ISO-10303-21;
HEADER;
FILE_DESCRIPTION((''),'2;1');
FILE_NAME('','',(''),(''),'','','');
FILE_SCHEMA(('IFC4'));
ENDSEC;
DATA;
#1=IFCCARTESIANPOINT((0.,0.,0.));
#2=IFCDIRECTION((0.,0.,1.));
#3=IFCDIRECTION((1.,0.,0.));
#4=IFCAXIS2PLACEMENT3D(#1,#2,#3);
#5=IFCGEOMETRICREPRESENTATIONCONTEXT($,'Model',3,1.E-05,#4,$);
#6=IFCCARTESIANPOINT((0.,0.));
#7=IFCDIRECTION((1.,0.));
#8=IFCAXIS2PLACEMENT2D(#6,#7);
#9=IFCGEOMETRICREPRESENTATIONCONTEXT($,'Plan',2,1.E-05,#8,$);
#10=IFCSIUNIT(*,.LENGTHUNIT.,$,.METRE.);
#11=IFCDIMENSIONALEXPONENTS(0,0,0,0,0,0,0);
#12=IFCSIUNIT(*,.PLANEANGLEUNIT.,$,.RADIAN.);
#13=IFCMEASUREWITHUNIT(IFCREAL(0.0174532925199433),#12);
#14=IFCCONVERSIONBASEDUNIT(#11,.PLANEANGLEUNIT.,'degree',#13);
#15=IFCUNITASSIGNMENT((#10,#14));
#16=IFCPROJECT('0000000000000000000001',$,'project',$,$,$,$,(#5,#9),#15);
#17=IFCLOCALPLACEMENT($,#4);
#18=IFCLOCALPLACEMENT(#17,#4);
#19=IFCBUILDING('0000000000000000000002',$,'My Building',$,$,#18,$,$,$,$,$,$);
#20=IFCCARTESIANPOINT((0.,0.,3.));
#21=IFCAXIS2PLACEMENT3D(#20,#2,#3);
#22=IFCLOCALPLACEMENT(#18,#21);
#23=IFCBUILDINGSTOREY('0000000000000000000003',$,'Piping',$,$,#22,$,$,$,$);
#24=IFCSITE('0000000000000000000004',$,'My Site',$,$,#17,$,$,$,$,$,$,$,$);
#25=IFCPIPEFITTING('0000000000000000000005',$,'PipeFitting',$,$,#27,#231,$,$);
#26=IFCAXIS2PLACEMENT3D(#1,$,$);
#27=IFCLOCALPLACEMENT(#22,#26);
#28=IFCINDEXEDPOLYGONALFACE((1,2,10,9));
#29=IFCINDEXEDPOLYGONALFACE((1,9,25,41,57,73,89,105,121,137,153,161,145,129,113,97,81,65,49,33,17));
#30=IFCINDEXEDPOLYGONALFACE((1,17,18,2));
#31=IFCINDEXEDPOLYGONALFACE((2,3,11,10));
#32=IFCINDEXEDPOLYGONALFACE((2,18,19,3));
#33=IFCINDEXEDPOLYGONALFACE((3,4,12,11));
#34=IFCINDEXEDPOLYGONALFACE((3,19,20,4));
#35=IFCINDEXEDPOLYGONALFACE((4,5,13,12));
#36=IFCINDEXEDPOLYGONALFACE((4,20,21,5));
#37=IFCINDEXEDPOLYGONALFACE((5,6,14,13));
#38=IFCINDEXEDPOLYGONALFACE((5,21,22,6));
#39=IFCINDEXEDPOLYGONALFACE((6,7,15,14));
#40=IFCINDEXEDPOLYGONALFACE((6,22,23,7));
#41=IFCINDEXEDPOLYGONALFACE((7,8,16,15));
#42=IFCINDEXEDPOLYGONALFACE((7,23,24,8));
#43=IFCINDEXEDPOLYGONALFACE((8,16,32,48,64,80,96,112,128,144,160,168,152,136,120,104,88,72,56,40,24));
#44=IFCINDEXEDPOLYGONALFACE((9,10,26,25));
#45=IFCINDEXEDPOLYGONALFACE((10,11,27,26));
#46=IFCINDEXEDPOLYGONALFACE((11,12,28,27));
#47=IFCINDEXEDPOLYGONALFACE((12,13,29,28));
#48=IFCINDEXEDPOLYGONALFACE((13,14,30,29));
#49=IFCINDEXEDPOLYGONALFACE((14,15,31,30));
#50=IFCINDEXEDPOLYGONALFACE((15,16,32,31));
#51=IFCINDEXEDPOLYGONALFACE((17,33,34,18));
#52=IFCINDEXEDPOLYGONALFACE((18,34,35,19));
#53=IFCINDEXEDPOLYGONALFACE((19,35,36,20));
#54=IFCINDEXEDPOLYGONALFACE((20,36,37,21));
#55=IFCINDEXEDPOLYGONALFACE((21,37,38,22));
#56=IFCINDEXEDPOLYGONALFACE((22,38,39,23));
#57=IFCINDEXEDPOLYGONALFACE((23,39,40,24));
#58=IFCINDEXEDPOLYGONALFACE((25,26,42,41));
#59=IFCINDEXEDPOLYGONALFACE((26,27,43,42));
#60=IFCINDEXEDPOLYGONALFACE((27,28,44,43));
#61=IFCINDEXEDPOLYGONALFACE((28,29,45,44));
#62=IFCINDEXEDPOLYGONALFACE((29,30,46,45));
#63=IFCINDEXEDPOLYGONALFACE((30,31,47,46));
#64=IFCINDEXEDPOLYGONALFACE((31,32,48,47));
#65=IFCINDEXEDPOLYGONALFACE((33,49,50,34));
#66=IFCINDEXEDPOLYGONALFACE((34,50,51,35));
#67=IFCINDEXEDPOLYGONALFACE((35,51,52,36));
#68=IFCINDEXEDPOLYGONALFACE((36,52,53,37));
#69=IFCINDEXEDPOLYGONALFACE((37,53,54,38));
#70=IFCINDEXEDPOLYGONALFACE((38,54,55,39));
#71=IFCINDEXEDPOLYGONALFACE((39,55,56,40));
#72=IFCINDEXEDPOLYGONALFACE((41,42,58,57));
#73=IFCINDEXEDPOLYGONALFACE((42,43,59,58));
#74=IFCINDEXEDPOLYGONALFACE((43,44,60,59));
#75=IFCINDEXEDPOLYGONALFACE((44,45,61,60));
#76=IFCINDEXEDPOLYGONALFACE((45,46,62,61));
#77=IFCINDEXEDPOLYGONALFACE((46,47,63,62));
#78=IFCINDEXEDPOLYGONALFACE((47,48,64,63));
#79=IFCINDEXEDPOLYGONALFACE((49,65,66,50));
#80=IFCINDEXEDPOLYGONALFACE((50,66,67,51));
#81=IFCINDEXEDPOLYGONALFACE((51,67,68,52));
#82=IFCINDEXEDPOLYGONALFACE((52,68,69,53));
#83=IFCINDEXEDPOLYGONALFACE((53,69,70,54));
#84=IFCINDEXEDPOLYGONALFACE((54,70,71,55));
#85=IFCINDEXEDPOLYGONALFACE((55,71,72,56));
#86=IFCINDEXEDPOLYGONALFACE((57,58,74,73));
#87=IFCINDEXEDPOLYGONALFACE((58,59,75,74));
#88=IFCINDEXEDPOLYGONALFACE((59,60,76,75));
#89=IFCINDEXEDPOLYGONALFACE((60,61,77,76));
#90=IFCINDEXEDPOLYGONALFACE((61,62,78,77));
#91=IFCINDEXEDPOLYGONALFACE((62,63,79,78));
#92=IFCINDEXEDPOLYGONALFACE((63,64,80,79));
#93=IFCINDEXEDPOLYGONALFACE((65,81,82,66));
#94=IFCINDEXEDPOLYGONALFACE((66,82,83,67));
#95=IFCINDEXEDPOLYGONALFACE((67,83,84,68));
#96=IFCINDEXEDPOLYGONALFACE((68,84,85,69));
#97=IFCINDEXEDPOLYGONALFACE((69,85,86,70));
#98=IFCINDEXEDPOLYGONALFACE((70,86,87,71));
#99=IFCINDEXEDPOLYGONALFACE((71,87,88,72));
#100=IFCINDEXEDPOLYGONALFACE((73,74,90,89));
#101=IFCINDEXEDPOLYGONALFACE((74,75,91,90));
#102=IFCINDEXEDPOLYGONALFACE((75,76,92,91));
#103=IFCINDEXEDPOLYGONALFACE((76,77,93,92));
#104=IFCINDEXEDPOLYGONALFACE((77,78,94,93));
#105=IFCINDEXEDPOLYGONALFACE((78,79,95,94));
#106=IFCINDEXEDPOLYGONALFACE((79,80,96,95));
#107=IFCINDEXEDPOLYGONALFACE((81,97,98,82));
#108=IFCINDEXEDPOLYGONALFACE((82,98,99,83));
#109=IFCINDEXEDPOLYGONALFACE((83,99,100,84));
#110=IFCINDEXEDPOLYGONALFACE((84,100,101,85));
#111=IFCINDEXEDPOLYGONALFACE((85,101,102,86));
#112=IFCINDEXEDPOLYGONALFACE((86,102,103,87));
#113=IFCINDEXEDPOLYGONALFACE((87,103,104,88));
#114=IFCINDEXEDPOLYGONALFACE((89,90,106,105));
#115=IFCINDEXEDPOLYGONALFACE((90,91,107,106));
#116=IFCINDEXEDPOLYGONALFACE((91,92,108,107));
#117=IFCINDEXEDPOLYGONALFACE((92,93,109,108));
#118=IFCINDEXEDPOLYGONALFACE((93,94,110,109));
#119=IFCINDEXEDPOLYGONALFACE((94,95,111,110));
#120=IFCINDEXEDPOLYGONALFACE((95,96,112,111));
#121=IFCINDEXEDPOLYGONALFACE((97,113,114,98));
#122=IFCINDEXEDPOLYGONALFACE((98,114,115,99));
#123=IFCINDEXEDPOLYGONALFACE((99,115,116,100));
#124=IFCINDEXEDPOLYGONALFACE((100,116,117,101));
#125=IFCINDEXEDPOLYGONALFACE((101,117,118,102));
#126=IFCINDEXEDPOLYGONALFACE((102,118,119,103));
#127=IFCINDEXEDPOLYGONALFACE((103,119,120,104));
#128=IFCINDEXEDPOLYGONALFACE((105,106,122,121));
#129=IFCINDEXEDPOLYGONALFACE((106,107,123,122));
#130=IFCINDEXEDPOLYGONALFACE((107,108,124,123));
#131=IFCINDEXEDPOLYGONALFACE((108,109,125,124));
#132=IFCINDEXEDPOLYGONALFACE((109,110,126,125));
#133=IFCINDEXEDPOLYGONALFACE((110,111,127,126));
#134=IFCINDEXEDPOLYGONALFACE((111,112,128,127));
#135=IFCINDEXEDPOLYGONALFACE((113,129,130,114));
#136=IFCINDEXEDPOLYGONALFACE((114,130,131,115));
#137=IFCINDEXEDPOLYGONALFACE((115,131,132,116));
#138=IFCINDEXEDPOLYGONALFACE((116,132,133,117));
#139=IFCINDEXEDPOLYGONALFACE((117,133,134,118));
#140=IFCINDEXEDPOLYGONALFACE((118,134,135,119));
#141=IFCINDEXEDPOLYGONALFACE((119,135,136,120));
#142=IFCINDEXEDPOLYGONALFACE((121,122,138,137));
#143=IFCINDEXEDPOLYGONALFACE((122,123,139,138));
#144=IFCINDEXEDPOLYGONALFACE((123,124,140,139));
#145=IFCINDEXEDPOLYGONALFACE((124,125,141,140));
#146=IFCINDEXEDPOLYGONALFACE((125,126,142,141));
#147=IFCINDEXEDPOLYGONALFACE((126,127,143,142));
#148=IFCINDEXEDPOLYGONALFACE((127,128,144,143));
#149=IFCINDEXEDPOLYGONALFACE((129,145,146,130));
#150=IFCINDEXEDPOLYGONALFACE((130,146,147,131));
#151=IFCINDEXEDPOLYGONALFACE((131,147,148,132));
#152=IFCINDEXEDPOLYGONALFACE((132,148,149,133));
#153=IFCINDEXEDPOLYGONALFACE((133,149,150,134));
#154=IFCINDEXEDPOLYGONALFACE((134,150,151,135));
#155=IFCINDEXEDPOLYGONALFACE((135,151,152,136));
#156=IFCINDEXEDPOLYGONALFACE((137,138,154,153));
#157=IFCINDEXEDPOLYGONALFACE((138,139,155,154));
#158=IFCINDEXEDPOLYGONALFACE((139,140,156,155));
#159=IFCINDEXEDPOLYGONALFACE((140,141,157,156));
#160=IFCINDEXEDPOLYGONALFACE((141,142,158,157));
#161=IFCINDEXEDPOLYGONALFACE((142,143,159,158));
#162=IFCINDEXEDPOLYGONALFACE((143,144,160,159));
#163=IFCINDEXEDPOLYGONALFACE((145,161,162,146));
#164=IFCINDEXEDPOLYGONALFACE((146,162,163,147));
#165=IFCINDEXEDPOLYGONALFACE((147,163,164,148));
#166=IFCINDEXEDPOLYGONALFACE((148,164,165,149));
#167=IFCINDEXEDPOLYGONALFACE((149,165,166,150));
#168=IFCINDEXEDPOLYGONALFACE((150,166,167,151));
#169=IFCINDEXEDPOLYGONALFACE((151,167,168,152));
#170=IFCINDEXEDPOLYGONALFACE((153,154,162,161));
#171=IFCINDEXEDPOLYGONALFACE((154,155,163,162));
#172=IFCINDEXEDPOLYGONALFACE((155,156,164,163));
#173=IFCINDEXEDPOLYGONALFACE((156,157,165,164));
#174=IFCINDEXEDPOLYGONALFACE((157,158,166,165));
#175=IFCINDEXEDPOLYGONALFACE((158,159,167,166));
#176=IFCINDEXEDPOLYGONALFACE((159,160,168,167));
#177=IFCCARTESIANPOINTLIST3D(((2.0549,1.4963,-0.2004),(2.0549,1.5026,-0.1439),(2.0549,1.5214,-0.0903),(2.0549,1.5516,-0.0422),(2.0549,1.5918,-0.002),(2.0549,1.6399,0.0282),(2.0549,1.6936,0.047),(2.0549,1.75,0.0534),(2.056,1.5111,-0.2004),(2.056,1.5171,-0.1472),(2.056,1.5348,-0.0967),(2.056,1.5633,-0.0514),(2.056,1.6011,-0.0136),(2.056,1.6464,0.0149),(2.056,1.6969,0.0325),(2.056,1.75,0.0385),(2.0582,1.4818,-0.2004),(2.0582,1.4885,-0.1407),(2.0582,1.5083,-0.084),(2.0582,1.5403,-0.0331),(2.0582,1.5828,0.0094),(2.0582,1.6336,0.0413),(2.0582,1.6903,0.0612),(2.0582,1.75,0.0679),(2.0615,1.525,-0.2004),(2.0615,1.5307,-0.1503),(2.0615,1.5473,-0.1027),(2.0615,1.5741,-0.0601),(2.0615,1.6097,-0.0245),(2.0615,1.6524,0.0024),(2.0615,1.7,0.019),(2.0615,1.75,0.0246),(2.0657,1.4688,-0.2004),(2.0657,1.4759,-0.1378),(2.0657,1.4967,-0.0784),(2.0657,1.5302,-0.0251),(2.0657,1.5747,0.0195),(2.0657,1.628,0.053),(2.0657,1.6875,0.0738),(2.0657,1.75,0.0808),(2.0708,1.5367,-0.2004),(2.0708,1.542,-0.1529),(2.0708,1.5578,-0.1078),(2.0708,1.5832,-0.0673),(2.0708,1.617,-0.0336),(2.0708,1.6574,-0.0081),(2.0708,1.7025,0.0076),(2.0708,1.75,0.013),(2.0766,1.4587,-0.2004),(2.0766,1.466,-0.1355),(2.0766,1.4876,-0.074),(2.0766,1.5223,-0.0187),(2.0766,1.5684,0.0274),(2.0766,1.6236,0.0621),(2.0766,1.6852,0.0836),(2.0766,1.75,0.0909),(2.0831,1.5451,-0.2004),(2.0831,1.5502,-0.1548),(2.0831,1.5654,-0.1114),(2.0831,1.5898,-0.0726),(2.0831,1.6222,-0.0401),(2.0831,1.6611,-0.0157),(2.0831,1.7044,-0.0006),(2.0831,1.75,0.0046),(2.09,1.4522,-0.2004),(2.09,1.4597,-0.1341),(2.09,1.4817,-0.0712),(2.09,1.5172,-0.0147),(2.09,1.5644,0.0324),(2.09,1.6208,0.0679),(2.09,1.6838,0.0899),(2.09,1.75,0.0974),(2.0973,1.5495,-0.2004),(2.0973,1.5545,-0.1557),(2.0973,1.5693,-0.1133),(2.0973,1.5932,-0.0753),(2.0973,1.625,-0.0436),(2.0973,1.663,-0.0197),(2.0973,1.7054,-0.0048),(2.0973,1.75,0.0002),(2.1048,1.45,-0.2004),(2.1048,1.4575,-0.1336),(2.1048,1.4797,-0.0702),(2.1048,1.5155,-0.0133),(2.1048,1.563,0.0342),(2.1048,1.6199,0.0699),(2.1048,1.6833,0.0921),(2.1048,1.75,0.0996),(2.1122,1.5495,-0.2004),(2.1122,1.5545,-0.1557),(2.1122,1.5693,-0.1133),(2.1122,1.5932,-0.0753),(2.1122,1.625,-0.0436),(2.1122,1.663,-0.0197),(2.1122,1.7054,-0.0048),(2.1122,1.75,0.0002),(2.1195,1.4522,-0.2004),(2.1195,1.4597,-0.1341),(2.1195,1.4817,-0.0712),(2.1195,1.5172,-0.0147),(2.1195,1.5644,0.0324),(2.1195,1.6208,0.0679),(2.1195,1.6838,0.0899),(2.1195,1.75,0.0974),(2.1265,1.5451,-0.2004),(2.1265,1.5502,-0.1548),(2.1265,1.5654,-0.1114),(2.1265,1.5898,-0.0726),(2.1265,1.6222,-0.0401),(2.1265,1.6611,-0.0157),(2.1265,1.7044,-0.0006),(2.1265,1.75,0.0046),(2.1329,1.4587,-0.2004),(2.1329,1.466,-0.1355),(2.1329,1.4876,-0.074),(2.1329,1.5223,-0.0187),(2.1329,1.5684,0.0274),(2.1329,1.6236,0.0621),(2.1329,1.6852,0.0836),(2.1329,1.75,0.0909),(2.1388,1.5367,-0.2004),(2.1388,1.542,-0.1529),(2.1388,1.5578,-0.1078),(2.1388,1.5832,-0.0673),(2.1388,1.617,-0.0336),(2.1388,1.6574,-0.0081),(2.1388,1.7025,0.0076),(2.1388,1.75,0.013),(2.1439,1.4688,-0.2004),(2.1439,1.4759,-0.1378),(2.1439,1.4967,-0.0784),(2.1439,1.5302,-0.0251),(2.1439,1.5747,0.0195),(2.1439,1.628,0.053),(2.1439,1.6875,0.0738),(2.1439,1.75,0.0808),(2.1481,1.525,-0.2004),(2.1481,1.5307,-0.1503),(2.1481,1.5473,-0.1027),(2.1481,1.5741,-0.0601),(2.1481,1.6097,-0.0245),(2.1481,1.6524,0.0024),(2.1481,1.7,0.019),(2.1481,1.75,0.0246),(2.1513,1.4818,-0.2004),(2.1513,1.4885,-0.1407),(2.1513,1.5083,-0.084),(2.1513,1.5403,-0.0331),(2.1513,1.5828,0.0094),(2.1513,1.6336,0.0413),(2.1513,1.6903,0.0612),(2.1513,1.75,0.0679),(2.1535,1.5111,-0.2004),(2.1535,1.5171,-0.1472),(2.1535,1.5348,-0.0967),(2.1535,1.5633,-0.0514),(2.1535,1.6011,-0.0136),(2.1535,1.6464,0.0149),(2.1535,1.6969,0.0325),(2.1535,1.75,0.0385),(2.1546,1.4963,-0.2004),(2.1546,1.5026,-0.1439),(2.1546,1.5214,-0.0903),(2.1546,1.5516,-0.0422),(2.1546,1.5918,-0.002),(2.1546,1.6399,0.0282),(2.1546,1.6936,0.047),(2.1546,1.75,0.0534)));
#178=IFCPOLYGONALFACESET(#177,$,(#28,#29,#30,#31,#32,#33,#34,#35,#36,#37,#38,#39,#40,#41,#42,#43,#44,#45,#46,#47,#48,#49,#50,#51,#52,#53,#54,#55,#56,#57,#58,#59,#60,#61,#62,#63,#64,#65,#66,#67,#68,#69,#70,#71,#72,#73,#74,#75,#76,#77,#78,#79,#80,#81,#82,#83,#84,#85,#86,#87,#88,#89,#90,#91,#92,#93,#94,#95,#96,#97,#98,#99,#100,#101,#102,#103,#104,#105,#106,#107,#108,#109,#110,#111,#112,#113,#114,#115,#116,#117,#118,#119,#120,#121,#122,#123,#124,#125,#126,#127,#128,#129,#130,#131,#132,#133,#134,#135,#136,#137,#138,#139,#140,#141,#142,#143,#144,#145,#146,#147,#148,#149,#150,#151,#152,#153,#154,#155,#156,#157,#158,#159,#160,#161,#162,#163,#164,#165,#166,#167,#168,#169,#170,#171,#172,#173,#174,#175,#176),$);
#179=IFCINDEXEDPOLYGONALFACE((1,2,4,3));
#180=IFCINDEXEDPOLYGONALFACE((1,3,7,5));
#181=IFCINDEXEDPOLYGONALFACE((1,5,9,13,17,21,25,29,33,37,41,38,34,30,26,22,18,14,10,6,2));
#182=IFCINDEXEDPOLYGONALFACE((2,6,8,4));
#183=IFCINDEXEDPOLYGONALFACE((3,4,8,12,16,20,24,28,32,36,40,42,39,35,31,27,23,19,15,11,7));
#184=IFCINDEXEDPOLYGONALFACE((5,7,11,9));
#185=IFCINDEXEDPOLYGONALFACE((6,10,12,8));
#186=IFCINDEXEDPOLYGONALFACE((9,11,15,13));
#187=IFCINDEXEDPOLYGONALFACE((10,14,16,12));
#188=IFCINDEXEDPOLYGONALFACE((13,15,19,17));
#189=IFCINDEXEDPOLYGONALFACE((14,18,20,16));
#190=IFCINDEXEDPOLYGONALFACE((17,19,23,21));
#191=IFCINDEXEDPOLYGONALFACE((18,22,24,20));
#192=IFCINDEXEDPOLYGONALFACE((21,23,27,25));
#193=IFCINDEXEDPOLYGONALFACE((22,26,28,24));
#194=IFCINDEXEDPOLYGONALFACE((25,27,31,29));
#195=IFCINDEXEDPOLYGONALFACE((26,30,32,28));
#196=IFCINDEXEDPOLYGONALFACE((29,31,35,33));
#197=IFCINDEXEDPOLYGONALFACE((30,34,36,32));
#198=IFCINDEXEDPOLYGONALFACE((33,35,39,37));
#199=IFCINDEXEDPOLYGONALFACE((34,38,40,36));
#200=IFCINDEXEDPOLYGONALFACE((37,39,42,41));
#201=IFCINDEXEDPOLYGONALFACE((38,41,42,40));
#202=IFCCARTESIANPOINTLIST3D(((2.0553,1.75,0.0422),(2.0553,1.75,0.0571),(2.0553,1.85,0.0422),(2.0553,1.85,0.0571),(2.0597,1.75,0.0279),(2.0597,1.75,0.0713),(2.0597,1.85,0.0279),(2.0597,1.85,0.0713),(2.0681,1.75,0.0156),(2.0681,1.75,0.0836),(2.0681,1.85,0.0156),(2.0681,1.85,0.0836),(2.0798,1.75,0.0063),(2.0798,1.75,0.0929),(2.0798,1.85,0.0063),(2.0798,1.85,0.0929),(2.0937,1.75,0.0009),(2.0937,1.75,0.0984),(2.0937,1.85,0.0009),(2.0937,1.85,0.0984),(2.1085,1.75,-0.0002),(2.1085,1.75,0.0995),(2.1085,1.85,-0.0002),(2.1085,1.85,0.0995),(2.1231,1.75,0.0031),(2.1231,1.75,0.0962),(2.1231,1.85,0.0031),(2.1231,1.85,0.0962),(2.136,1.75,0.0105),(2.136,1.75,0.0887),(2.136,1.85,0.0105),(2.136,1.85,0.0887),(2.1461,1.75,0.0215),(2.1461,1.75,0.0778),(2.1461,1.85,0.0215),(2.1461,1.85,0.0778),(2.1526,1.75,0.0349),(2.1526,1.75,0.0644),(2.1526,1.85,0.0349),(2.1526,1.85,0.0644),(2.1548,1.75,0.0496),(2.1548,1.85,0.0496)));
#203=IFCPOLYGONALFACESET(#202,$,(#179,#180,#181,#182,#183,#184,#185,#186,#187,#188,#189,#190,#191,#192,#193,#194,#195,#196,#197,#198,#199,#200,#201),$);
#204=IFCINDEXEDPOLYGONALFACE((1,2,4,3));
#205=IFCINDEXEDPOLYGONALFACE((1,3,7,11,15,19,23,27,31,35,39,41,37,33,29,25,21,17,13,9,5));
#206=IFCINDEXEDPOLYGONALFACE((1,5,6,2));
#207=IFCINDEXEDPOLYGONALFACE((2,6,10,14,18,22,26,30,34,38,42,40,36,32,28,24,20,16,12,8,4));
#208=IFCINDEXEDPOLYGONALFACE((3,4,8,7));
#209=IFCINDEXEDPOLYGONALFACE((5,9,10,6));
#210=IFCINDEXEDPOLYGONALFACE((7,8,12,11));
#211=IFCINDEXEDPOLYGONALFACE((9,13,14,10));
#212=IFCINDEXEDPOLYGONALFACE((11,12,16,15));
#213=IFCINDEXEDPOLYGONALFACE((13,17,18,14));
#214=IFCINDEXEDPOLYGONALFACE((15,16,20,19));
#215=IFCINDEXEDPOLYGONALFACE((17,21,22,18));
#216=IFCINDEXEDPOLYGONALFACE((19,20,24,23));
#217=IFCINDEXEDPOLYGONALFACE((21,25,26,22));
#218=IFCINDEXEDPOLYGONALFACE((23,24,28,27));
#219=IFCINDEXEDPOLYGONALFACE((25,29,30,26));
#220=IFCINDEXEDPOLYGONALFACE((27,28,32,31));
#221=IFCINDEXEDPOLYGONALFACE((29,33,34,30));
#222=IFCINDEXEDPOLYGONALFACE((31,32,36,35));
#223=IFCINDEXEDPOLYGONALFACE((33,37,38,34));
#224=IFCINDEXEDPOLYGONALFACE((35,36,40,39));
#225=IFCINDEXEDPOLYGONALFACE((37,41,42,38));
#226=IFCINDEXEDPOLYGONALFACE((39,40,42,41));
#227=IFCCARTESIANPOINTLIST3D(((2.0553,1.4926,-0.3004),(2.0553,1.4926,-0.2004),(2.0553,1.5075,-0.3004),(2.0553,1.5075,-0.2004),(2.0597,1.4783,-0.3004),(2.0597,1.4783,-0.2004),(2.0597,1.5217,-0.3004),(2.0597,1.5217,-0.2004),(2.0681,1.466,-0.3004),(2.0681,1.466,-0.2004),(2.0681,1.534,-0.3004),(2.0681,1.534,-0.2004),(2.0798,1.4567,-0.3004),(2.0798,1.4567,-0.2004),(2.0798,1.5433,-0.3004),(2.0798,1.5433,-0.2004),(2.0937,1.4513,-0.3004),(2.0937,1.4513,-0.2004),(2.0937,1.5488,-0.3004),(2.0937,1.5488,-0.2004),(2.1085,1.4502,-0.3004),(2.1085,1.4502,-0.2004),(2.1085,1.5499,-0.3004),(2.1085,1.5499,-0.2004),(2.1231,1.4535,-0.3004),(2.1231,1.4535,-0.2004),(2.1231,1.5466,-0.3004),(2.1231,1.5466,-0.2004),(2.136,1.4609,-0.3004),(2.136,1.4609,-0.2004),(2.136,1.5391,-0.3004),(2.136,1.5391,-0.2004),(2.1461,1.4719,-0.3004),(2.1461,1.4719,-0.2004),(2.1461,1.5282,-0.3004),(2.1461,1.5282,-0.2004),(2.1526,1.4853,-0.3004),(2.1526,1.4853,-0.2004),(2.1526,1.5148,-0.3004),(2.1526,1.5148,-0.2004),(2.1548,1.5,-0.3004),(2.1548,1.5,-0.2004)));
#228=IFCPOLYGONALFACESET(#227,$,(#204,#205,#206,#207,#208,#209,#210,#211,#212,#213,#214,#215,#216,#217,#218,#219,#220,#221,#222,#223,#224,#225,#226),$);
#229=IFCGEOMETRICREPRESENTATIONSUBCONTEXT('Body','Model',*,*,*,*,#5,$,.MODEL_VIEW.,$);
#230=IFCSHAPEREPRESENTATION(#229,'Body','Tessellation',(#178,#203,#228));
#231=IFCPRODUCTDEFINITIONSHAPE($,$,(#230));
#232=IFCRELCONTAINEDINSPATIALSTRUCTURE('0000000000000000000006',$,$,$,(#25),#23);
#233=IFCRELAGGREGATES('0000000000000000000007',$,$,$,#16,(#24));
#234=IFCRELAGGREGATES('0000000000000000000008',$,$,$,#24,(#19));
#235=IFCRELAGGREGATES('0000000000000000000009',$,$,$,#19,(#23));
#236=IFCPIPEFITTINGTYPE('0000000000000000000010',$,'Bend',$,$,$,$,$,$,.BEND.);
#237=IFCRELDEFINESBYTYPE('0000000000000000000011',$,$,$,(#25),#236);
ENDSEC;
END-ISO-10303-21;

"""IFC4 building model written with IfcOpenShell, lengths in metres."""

from ifc_helpers import new_model, entity, si_unit, converted_unit, frame, origin_with_axes, origin_2d_with_axis, place, context, subcontext, project, spatial, circle, extrude, source, transform, mapped, type_object, type_shapes, element, save


model = new_model("IFC4")

# Units and contexts
model_context = context("Model", 3, precision=1e-05, world=origin_with_axes())
plan_context = context("Plan", 2, precision=1e-05, world=origin_2d_with_axis())
body_context = subcontext(model_context, "Body", "Model", "MODEL_VIEW")
ifc_project = project(units=[si_unit("LENGTHUNIT", "METRE"), converted_unit("PLANEANGLEUNIT", "degree", entity("IfcReal", 0.0174532925199433), si_unit("PLANEANGLEUNIT", "RADIAN"), dimensions=[0, 0, 0, 0, 0, 0, 0])], contexts=[model_context, plan_context])

# Site, building, storey
site_placement = place(None, origin_with_axes())
site = spatial("IfcSite", under=ifc_project, at=site_placement, Name="My Site")
building_placement = place(site_placement, origin_with_axes())
building = spatial("IfcBuilding", under=site, at=building_placement, Name="My Building")
storey_placement = place(building_placement, frame((0.0, 0.0, 3.0), z_axis=(0.0, 0.0, 1.0), x_axis=(1.0, 0.0, 0.0)))
storey = spatial("IfcBuildingStorey", under=building, at=storey_placement, Name="Piping")

# Pipe fitting
pipe_fitting_type_1 = type_object("IfcPipeFittingType", Name="Bend", PredefinedType="BEND")
shared_shape = source(origin_with_axes(), body_context, "Body", "SolidModel", [
    entity("IfcSweptDiskSolid", entity("IfcIndexedPolyCurve", entity("IfcCartesianPointList3D", [[0.0, 0.0, 0.1], [0.0, -0.0732, 0.2768], [0.0, -0.25, 0.35]]), [entity("IfcArcIndex", [1, 2, 3])]), 0.05),
    extrude(circle(Radius=0.05), origin_with_axes(), (0.0, 0.0, 1.0), 0.1),
    extrude(circle(Radius=0.05), frame((0.0, -0.25, 0.35), z_axis=(0.0, -1.0, 0.0), x_axis=(1.0, 0.0, 0.0)), (0.0, 0.0, 1.0), 0.1),
])
type_shapes(pipe_fitting_type_1, [shared_shape])
for number, where, z_axis, x_axis, name in (
    (1, (2.1048, 1.85, 0.0496), (0.0, -1.0, 0.0), (1.0, 0.0, 0.0), "PipeFitting"),
):
    element("IfcPipeFitting", number, at=place(storey_placement, frame(where, z_axis=z_axis, x_axis=x_axis)), inside=storey, type_object=pipe_fitting_type_1, Name=name, context=body_context, shape_type="MappedRepresentation", body=[
        mapped(shared_shape, transform((0.0, 0.0, 0.0), x_axis=(1.0, 0.0, 0.0), y_axis=(0.0, 1.0, 0.0), z_axis=(0.0, 0.0, 1.0), scale=1.0)),
    ])

save(model, "model.ifc")
